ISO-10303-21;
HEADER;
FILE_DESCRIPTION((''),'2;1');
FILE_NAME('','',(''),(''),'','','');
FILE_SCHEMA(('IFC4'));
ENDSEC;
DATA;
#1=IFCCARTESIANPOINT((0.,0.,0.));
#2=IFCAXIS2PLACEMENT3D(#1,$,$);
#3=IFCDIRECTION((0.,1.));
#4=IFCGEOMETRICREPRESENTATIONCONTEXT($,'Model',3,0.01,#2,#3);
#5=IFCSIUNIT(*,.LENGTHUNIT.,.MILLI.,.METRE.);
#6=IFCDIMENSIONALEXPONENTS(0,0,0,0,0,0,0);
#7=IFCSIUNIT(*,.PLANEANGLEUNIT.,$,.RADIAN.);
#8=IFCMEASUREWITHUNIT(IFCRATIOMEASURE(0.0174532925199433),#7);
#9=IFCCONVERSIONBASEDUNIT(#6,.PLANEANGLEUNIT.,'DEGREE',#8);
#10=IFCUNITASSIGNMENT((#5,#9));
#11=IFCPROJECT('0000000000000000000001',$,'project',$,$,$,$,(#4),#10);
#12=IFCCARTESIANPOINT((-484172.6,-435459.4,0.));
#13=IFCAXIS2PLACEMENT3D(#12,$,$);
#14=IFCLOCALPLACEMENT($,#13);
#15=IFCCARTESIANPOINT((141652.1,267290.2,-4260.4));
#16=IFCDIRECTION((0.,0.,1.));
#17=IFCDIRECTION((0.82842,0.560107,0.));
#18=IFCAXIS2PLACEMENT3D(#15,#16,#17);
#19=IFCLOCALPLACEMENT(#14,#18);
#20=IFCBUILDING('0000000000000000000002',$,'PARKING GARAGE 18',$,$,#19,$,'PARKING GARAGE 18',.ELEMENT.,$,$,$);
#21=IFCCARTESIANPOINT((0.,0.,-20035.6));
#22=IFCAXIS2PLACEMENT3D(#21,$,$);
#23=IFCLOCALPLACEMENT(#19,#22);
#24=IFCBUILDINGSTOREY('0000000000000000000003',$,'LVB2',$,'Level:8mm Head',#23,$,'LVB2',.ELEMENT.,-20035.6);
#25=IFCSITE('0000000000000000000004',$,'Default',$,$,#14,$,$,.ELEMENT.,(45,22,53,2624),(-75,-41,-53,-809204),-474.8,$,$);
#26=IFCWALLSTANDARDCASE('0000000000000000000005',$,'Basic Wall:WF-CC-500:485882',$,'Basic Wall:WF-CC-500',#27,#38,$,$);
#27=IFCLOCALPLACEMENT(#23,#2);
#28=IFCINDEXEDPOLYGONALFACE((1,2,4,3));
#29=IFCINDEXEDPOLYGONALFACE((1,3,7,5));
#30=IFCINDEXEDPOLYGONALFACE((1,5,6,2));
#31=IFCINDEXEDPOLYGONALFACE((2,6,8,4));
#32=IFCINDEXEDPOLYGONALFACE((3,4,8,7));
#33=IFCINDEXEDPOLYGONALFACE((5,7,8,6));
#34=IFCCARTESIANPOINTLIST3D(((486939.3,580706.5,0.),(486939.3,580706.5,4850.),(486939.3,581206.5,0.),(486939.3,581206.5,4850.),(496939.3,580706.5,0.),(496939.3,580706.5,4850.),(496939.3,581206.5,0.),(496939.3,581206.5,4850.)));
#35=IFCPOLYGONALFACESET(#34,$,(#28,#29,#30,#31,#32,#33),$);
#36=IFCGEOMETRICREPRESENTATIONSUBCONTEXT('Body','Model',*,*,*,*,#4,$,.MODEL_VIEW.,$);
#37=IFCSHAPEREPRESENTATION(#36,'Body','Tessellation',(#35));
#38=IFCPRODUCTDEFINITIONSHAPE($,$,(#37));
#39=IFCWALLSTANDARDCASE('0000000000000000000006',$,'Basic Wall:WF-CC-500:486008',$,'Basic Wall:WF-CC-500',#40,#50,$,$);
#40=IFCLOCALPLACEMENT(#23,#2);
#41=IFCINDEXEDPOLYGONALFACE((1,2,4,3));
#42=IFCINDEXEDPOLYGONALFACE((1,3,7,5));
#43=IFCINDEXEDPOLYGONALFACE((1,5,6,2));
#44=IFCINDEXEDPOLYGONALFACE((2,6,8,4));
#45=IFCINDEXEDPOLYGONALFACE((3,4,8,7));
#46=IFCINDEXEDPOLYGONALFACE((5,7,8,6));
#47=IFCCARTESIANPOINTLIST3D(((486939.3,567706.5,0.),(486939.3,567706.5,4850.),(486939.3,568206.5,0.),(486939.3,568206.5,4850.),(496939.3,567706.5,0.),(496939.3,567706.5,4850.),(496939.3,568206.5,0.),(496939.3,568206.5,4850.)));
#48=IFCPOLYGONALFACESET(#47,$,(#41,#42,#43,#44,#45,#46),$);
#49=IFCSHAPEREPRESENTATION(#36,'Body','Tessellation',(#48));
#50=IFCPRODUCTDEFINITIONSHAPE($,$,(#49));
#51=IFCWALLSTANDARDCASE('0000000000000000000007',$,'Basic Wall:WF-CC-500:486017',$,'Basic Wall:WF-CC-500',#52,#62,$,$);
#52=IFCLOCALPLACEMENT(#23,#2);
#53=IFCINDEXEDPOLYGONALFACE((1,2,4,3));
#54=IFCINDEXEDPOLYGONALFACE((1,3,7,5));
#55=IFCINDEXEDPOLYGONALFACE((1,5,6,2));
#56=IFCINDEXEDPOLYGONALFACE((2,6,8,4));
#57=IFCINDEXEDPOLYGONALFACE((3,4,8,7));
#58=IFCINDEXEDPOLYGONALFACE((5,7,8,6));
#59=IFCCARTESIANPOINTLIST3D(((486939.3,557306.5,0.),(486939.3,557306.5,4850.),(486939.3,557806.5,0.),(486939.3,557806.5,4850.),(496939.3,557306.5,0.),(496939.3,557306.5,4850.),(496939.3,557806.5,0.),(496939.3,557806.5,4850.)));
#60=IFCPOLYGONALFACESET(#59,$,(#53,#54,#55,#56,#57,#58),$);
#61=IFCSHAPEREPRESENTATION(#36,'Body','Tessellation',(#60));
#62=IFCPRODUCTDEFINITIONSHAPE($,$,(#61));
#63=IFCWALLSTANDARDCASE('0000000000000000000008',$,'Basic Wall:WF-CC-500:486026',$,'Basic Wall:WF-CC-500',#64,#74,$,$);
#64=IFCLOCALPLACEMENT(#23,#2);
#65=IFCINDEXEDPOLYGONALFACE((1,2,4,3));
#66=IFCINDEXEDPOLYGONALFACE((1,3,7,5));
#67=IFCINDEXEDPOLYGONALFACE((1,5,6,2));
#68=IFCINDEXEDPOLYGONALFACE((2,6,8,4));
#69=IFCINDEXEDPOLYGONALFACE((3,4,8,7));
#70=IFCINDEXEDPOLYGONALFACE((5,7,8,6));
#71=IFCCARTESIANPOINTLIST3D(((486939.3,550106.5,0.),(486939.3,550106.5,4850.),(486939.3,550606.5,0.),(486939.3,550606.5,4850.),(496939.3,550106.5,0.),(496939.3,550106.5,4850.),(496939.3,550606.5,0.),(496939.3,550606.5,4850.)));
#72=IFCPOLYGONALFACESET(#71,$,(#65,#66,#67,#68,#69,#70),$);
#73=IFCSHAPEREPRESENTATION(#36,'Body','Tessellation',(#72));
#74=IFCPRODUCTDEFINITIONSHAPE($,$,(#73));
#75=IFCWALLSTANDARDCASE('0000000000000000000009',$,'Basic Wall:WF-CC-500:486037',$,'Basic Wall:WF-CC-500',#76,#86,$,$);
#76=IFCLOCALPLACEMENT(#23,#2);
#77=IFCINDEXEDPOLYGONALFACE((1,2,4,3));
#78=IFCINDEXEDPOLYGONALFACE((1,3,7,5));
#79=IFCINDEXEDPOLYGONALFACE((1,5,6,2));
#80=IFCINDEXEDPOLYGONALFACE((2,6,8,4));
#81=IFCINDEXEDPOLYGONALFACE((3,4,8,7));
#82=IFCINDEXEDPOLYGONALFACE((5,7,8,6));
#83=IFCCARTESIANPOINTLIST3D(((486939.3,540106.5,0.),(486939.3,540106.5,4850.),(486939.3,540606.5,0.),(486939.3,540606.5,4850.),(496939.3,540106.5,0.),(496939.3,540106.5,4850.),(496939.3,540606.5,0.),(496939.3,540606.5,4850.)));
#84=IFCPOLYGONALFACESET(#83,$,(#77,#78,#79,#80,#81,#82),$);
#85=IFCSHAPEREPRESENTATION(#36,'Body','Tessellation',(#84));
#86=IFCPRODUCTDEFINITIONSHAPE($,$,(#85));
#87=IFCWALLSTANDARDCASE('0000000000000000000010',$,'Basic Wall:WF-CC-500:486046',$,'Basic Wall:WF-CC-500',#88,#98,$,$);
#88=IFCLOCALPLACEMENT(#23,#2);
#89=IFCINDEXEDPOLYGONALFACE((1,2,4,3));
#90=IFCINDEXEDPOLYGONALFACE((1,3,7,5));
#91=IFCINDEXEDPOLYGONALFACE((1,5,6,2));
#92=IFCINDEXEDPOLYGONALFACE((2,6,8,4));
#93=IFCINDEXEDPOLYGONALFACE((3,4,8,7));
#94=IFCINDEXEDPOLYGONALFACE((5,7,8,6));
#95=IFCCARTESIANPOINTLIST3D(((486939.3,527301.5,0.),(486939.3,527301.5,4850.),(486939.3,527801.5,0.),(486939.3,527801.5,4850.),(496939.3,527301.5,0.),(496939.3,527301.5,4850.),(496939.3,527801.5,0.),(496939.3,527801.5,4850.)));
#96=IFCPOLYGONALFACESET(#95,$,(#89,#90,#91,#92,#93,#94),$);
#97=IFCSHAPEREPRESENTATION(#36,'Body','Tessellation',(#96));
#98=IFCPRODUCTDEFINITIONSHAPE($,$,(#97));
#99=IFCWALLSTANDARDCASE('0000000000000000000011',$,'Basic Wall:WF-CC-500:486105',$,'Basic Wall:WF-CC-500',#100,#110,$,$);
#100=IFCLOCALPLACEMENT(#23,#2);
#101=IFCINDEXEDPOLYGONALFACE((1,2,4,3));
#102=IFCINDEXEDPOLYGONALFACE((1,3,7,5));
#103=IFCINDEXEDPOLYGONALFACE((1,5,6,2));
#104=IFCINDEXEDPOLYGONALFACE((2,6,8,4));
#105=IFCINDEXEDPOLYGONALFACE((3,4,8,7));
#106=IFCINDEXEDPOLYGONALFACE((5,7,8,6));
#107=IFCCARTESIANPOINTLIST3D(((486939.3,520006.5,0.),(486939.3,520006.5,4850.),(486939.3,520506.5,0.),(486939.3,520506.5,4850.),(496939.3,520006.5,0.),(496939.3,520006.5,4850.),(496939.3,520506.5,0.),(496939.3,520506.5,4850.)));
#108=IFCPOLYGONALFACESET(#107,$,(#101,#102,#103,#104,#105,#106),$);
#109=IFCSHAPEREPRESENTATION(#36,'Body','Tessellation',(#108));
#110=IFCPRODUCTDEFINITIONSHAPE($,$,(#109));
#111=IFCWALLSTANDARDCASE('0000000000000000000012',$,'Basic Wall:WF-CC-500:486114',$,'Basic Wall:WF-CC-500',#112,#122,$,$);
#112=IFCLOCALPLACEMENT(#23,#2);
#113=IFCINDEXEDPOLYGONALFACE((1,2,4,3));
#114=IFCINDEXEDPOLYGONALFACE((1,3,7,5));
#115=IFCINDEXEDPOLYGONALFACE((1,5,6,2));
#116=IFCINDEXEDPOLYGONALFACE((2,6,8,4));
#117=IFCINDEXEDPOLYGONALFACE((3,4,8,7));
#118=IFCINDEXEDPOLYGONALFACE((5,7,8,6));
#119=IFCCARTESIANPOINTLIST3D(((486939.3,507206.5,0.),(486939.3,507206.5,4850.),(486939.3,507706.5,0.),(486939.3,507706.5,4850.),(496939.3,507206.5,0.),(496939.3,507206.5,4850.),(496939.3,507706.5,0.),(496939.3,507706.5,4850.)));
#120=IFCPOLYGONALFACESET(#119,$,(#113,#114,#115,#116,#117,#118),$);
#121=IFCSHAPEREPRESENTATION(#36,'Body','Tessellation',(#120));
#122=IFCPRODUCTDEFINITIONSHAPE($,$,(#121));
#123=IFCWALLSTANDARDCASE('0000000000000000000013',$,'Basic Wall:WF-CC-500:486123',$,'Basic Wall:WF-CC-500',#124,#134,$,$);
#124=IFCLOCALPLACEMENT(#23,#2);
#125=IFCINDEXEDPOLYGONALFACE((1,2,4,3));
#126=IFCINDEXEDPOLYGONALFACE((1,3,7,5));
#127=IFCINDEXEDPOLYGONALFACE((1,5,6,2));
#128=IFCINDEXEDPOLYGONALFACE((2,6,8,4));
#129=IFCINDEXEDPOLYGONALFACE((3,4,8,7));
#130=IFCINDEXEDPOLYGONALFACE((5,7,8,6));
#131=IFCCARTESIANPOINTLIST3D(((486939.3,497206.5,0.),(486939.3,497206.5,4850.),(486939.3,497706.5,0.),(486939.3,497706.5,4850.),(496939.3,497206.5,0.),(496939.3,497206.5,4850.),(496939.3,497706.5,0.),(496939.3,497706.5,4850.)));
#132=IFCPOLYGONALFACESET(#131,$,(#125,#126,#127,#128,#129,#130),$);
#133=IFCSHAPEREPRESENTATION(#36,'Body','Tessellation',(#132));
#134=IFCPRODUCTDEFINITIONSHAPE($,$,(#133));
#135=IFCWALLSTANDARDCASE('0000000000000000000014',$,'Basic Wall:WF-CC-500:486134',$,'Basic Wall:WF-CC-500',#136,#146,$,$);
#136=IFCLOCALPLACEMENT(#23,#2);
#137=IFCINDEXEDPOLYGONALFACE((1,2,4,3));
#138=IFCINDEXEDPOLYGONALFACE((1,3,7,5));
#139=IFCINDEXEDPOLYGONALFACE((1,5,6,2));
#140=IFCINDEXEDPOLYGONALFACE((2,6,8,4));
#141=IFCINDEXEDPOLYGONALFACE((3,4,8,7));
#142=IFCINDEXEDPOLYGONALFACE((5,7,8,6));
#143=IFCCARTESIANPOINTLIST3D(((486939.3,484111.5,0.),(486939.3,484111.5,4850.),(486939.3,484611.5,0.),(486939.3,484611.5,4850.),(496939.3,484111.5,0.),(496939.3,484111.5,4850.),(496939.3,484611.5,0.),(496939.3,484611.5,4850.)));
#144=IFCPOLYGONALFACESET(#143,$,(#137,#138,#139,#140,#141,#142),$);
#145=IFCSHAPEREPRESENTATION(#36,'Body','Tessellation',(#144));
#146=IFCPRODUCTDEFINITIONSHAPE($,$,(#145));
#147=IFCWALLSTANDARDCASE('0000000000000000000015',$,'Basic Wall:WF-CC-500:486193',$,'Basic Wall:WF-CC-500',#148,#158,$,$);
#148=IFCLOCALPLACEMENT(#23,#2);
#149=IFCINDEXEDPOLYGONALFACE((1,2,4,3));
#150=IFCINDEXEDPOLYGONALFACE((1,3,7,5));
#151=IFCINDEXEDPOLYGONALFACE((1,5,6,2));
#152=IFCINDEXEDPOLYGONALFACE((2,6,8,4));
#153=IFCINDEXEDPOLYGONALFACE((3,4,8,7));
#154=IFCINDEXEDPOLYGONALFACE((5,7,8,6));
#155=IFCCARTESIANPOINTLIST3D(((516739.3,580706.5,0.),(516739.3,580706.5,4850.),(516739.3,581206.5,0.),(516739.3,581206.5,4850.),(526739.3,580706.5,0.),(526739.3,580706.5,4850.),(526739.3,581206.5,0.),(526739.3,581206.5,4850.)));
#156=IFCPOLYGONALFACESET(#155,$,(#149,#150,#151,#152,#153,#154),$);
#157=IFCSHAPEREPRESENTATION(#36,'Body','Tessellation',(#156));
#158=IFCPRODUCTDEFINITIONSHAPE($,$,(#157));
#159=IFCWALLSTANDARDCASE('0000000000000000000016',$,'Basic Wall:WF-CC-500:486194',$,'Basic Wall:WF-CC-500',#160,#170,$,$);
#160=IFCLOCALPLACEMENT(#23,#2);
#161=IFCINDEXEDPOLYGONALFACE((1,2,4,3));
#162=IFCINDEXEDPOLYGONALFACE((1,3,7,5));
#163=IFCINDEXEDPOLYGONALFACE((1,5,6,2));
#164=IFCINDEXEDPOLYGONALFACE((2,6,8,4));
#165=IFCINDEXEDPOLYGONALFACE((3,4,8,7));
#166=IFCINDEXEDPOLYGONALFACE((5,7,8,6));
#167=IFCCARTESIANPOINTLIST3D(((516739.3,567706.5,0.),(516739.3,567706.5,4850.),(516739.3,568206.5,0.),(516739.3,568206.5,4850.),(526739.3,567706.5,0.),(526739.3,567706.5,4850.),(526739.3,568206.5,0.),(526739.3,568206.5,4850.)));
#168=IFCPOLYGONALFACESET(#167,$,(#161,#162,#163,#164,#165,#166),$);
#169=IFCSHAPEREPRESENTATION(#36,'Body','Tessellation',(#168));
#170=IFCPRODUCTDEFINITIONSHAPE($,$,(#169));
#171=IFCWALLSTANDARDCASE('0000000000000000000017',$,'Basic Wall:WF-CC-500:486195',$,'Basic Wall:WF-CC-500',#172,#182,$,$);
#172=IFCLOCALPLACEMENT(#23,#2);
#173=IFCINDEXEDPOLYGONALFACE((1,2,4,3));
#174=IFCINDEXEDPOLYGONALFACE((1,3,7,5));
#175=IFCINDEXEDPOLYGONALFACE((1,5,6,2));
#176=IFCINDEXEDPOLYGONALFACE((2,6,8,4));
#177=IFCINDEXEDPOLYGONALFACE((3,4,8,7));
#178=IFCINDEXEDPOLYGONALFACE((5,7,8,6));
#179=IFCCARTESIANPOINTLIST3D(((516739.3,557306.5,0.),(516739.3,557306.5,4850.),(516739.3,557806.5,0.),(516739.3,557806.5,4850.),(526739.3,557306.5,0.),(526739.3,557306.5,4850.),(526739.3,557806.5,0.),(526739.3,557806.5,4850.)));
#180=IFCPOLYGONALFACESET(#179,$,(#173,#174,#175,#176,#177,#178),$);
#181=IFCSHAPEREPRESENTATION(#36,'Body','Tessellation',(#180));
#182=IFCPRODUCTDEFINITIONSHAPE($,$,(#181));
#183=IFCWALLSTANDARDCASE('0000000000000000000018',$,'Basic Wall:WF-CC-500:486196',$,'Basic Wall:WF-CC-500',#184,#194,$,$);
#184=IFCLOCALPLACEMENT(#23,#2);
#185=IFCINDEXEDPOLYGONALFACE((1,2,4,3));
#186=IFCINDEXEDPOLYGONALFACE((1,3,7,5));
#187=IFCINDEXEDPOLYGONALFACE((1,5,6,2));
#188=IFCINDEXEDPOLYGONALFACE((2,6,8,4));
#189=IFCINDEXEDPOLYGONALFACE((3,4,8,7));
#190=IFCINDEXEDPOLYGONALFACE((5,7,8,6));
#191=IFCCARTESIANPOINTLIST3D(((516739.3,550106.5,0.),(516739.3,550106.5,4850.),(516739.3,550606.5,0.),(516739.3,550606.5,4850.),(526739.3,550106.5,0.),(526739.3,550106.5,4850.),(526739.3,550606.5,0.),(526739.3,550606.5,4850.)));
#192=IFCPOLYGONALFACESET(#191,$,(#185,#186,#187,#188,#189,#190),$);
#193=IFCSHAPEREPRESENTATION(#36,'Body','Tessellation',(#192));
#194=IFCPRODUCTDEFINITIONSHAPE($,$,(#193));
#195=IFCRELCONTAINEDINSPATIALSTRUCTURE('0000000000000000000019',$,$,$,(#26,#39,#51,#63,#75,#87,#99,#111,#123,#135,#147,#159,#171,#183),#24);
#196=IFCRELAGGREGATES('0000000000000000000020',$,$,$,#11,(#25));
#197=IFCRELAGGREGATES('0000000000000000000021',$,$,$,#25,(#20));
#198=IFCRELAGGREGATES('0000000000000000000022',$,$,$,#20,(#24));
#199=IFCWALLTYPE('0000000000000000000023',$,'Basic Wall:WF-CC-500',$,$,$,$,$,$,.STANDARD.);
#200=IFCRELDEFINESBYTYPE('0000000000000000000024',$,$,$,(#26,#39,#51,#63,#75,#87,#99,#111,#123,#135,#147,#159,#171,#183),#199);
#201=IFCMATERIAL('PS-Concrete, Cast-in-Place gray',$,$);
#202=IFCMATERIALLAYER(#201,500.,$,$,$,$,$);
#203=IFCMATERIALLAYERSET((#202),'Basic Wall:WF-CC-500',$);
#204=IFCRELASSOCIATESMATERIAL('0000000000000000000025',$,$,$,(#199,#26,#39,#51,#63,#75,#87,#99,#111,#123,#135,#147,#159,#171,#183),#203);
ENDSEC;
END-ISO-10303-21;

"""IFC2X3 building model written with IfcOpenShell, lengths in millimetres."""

from ifc_helpers import new_model, entity, si_unit, converted_unit, direction, frame, frame_2d, origin, place, context, subcontext, project, spatial, rectangle, extrude, material, layer, layer_set, layer_usage, type_object, element, save


model = new_model("IFC2X3")

# Units and contexts
model_context = context("Model", 3, precision=0.01, world=origin(), true_north=direction((0.0, 1.0)))
body_context = subcontext(model_context, "Body", "Model", "MODEL_VIEW")
ifc_project = project(units=[si_unit("LENGTHUNIT", "METRE", prefix="MILLI"), converted_unit("PLANEANGLEUNIT", "DEGREE", entity("IfcRatioMeasure", 0.0174532925199433), si_unit("PLANEANGLEUNIT", "RADIAN"), dimensions=[0, 0, 0, 0, 0, 0, 0])], contexts=[model_context])

# Site, building, storey
site_placement = place(None, frame((-484172.6, -435459.4, 0.0)))
site = spatial("IfcSite", under=ifc_project, at=site_placement, Name="Default", CompositionType="ELEMENT", RefLatitude=(45, 22, 53, 2624), RefLongitude=(-75, -41, -53, -809204), RefElevation=-474.8)
building_placement = place(site_placement, frame((141652.1, 267290.2, -4260.4), z_axis=(0.0, 0.0, 1.0), x_axis=(0.82842, 0.560107, 0.0)))
building = spatial("IfcBuilding", under=site, at=building_placement, Name="PARKING GARAGE 18", LongName="PARKING GARAGE 18", CompositionType="ELEMENT")
storey_placement = place(building_placement, frame((0.0, 0.0, -20035.6)))
storey = spatial("IfcBuildingStorey", under=building, at=storey_placement, Name="LVB2", ObjectType="Level:8mm Head", LongName="LVB2", CompositionType="ELEMENT", Elevation=-20035.6)

# Walls
ifc_material = material(Name="PS-Concrete, Cast-in-Place gray")
ifc_layer = layer(ifc_material, 500.0)
ifc_layer_set = layer_set([ifc_layer], Name="Basic Wall:WF-CC-500")
ifc_layer_usage_1 = layer_usage(ifc_layer_set, "AXIS2", "NEGATIVE", 250.0)
wall_type = type_object("IfcWallType", Name="Basic Wall:WF-CC-500", PredefinedType="STANDARD", material=ifc_layer_set)
wall_1_placement = place(storey_placement, frame((486939.3, 580956.5, 0.0)))
element("IfcWallStandardCase", 1, at=wall_1_placement, inside=storey, type_object=wall_type, material=ifc_layer_usage_1, Name="Basic Wall:WF-CC-500:485882", ObjectType="Basic Wall:WF-CC-500", context=body_context, shape_type="SweptSolid", body=[
    extrude(rectangle(XDim=10000.0, YDim=500.0, at=frame_2d((5000.0, 0.0), x_axis=(-1.0, 0.0))), origin(), (0.0, 0.0, 1.0), 4850.0),
])
ifc_layer_usage_2 = layer_usage(ifc_layer_set, "AXIS2", "NEGATIVE", 250.0)
wall_2_placement = place(storey_placement, frame((486939.3, 567956.5, 0.0)))
element("IfcWallStandardCase", 2, at=wall_2_placement, inside=storey, type_object=wall_type, material=ifc_layer_usage_2, Name="Basic Wall:WF-CC-500:486008", ObjectType="Basic Wall:WF-CC-500", context=body_context, shape_type="SweptSolid", body=[
    extrude(rectangle(XDim=10000.0, YDim=500.0, at=frame_2d((5000.0, 0.0), x_axis=(-1.0, 0.0))), origin(), (0.0, 0.0, 1.0), 4850.0),
])
ifc_layer_usage_3 = layer_usage(ifc_layer_set, "AXIS2", "NEGATIVE", 250.0)
wall_3_placement = place(storey_placement, frame((486939.3, 557556.5, 0.0)))
element("IfcWallStandardCase", 3, at=wall_3_placement, inside=storey, type_object=wall_type, material=ifc_layer_usage_3, Name="Basic Wall:WF-CC-500:486017", ObjectType="Basic Wall:WF-CC-500", context=body_context, shape_type="SweptSolid", body=[
    extrude(rectangle(XDim=10000.0, YDim=500.0, at=frame_2d((5000.0, 0.0), x_axis=(-1.0, 0.0))), origin(), (0.0, 0.0, 1.0), 4850.0),
])
ifc_layer_usage_4 = layer_usage(ifc_layer_set, "AXIS2", "NEGATIVE", 250.0)
wall_4_placement = place(storey_placement, frame((486939.3, 550356.5, 0.0)))
element("IfcWallStandardCase", 4, at=wall_4_placement, inside=storey, type_object=wall_type, material=ifc_layer_usage_4, Name="Basic Wall:WF-CC-500:486026", ObjectType="Basic Wall:WF-CC-500", context=body_context, shape_type="SweptSolid", body=[
    extrude(rectangle(XDim=10000.0, YDim=500.0, at=frame_2d((5000.0, 0.0), x_axis=(-1.0, 0.0))), origin(), (0.0, 0.0, 1.0), 4850.0),
])
ifc_layer_usage_5 = layer_usage(ifc_layer_set, "AXIS2", "NEGATIVE", 250.0)
wall_5_placement = place(storey_placement, frame((486939.3, 540356.5, 0.0)))
element("IfcWallStandardCase", 5, at=wall_5_placement, inside=storey, type_object=wall_type, material=ifc_layer_usage_5, Name="Basic Wall:WF-CC-500:486037", ObjectType="Basic Wall:WF-CC-500", context=body_context, shape_type="SweptSolid", body=[
    extrude(rectangle(XDim=10000.0, YDim=500.0, at=frame_2d((5000.0, 0.0), x_axis=(-1.0, 0.0))), origin(), (0.0, 0.0, 1.0), 4850.0),
])
ifc_layer_usage_6 = layer_usage(ifc_layer_set, "AXIS2", "NEGATIVE", 250.0)
wall_6_placement = place(storey_placement, frame((486939.3, 527551.5, 0.0)))
element("IfcWallStandardCase", 6, at=wall_6_placement, inside=storey, type_object=wall_type, material=ifc_layer_usage_6, Name="Basic Wall:WF-CC-500:486046", ObjectType="Basic Wall:WF-CC-500", context=body_context, shape_type="SweptSolid", body=[
    extrude(rectangle(XDim=10000.0, YDim=500.0, at=frame_2d((5000.0, 0.0), x_axis=(-1.0, 0.0))), origin(), (0.0, 0.0, 1.0), 4850.0),
])
ifc_layer_usage_7 = layer_usage(ifc_layer_set, "AXIS2", "NEGATIVE", 250.0)
wall_7_placement = place(storey_placement, frame((486939.3, 520256.5, 0.0)))
element("IfcWallStandardCase", 7, at=wall_7_placement, inside=storey, type_object=wall_type, material=ifc_layer_usage_7, Name="Basic Wall:WF-CC-500:486105", ObjectType="Basic Wall:WF-CC-500", context=body_context, shape_type="SweptSolid", body=[
    extrude(rectangle(XDim=10000.0, YDim=500.0, at=frame_2d((5000.0, 0.0), x_axis=(-1.0, 0.0))), origin(), (0.0, 0.0, 1.0), 4850.0),
])
ifc_layer_usage_8 = layer_usage(ifc_layer_set, "AXIS2", "NEGATIVE", 250.0)
wall_8_placement = place(storey_placement, frame((486939.3, 507456.5, 0.0)))
element("IfcWallStandardCase", 8, at=wall_8_placement, inside=storey, type_object=wall_type, material=ifc_layer_usage_8, Name="Basic Wall:WF-CC-500:486114", ObjectType="Basic Wall:WF-CC-500", context=body_context, shape_type="SweptSolid", body=[
    extrude(rectangle(XDim=10000.0, YDim=500.0, at=frame_2d((5000.0, 0.0), x_axis=(-1.0, 0.0))), origin(), (0.0, 0.0, 1.0), 4850.0),
])
ifc_layer_usage_9 = layer_usage(ifc_layer_set, "AXIS2", "NEGATIVE", 250.0)
wall_9_placement = place(storey_placement, frame((486939.3, 497456.5, 0.0)))
element("IfcWallStandardCase", 9, at=wall_9_placement, inside=storey, type_object=wall_type, material=ifc_layer_usage_9, Name="Basic Wall:WF-CC-500:486123", ObjectType="Basic Wall:WF-CC-500", context=body_context, shape_type="SweptSolid", body=[
    extrude(rectangle(XDim=10000.0, YDim=500.0, at=frame_2d((5000.0, 0.0), x_axis=(-1.0, 0.0))), origin(), (0.0, 0.0, 1.0), 4850.0),
])
ifc_layer_usage_10 = layer_usage(ifc_layer_set, "AXIS2", "NEGATIVE", 250.0)
wall_10_placement = place(storey_placement, frame((486939.3, 484361.5, 0.0)))
element("IfcWallStandardCase", 10, at=wall_10_placement, inside=storey, type_object=wall_type, material=ifc_layer_usage_10, Name="Basic Wall:WF-CC-500:486134", ObjectType="Basic Wall:WF-CC-500", context=body_context, shape_type="SweptSolid", body=[
    extrude(rectangle(XDim=10000.0, YDim=500.0, at=frame_2d((5000.0, 0.0), x_axis=(-1.0, 0.0))), origin(), (0.0, 0.0, 1.0), 4850.0),
])
ifc_layer_usage_11 = layer_usage(ifc_layer_set, "AXIS2", "NEGATIVE", 250.0)
wall_11_placement = place(storey_placement, frame((516739.3, 580956.5, 0.0)))
element("IfcWallStandardCase", 11, at=wall_11_placement, inside=storey, type_object=wall_type, material=ifc_layer_usage_11, Name="Basic Wall:WF-CC-500:486193", ObjectType="Basic Wall:WF-CC-500", context=body_context, shape_type="SweptSolid", body=[
    extrude(rectangle(XDim=10000.0, YDim=500.0, at=frame_2d((5000.0, 0.0), x_axis=(-1.0, 0.0))), origin(), (0.0, 0.0, 1.0), 4850.0),
])
ifc_layer_usage_12 = layer_usage(ifc_layer_set, "AXIS2", "NEGATIVE", 250.0)
wall_12_placement = place(storey_placement, frame((516739.3, 567956.5, 0.0)))
element("IfcWallStandardCase", 12, at=wall_12_placement, inside=storey, type_object=wall_type, material=ifc_layer_usage_12, Name="Basic Wall:WF-CC-500:486194", ObjectType="Basic Wall:WF-CC-500", context=body_context, shape_type="SweptSolid", body=[
    extrude(rectangle(XDim=10000.0, YDim=500.0, at=frame_2d((5000.0, 0.0), x_axis=(-1.0, 0.0))), origin(), (0.0, 0.0, 1.0), 4850.0),
])
ifc_layer_usage_13 = layer_usage(ifc_layer_set, "AXIS2", "NEGATIVE", 250.0)
wall_13_placement = place(storey_placement, frame((516739.3, 557556.5, 0.0)))
element("IfcWallStandardCase", 13, at=wall_13_placement, inside=storey, type_object=wall_type, material=ifc_layer_usage_13, Name="Basic Wall:WF-CC-500:486195", ObjectType="Basic Wall:WF-CC-500", context=body_context, shape_type="SweptSolid", body=[
    extrude(rectangle(XDim=10000.0, YDim=500.0, at=frame_2d((5000.0, 0.0), x_axis=(-1.0, 0.0))), origin(), (0.0, 0.0, 1.0), 4850.0),
])
ifc_layer_usage_14 = layer_usage(ifc_layer_set, "AXIS2", "NEGATIVE", 250.0)
wall_14_placement = place(storey_placement, frame((516739.3, 550356.5, 0.0)))
element("IfcWallStandardCase", 14, at=wall_14_placement, inside=storey, type_object=wall_type, material=ifc_layer_usage_14, Name="Basic Wall:WF-CC-500:486196", ObjectType="Basic Wall:WF-CC-500", context=body_context, shape_type="SweptSolid", body=[
    extrude(rectangle(XDim=10000.0, YDim=500.0, at=frame_2d((5000.0, 0.0), x_axis=(-1.0, 0.0))), origin(), (0.0, 0.0, 1.0), 4850.0),
])

save(model, "model.ifc")
